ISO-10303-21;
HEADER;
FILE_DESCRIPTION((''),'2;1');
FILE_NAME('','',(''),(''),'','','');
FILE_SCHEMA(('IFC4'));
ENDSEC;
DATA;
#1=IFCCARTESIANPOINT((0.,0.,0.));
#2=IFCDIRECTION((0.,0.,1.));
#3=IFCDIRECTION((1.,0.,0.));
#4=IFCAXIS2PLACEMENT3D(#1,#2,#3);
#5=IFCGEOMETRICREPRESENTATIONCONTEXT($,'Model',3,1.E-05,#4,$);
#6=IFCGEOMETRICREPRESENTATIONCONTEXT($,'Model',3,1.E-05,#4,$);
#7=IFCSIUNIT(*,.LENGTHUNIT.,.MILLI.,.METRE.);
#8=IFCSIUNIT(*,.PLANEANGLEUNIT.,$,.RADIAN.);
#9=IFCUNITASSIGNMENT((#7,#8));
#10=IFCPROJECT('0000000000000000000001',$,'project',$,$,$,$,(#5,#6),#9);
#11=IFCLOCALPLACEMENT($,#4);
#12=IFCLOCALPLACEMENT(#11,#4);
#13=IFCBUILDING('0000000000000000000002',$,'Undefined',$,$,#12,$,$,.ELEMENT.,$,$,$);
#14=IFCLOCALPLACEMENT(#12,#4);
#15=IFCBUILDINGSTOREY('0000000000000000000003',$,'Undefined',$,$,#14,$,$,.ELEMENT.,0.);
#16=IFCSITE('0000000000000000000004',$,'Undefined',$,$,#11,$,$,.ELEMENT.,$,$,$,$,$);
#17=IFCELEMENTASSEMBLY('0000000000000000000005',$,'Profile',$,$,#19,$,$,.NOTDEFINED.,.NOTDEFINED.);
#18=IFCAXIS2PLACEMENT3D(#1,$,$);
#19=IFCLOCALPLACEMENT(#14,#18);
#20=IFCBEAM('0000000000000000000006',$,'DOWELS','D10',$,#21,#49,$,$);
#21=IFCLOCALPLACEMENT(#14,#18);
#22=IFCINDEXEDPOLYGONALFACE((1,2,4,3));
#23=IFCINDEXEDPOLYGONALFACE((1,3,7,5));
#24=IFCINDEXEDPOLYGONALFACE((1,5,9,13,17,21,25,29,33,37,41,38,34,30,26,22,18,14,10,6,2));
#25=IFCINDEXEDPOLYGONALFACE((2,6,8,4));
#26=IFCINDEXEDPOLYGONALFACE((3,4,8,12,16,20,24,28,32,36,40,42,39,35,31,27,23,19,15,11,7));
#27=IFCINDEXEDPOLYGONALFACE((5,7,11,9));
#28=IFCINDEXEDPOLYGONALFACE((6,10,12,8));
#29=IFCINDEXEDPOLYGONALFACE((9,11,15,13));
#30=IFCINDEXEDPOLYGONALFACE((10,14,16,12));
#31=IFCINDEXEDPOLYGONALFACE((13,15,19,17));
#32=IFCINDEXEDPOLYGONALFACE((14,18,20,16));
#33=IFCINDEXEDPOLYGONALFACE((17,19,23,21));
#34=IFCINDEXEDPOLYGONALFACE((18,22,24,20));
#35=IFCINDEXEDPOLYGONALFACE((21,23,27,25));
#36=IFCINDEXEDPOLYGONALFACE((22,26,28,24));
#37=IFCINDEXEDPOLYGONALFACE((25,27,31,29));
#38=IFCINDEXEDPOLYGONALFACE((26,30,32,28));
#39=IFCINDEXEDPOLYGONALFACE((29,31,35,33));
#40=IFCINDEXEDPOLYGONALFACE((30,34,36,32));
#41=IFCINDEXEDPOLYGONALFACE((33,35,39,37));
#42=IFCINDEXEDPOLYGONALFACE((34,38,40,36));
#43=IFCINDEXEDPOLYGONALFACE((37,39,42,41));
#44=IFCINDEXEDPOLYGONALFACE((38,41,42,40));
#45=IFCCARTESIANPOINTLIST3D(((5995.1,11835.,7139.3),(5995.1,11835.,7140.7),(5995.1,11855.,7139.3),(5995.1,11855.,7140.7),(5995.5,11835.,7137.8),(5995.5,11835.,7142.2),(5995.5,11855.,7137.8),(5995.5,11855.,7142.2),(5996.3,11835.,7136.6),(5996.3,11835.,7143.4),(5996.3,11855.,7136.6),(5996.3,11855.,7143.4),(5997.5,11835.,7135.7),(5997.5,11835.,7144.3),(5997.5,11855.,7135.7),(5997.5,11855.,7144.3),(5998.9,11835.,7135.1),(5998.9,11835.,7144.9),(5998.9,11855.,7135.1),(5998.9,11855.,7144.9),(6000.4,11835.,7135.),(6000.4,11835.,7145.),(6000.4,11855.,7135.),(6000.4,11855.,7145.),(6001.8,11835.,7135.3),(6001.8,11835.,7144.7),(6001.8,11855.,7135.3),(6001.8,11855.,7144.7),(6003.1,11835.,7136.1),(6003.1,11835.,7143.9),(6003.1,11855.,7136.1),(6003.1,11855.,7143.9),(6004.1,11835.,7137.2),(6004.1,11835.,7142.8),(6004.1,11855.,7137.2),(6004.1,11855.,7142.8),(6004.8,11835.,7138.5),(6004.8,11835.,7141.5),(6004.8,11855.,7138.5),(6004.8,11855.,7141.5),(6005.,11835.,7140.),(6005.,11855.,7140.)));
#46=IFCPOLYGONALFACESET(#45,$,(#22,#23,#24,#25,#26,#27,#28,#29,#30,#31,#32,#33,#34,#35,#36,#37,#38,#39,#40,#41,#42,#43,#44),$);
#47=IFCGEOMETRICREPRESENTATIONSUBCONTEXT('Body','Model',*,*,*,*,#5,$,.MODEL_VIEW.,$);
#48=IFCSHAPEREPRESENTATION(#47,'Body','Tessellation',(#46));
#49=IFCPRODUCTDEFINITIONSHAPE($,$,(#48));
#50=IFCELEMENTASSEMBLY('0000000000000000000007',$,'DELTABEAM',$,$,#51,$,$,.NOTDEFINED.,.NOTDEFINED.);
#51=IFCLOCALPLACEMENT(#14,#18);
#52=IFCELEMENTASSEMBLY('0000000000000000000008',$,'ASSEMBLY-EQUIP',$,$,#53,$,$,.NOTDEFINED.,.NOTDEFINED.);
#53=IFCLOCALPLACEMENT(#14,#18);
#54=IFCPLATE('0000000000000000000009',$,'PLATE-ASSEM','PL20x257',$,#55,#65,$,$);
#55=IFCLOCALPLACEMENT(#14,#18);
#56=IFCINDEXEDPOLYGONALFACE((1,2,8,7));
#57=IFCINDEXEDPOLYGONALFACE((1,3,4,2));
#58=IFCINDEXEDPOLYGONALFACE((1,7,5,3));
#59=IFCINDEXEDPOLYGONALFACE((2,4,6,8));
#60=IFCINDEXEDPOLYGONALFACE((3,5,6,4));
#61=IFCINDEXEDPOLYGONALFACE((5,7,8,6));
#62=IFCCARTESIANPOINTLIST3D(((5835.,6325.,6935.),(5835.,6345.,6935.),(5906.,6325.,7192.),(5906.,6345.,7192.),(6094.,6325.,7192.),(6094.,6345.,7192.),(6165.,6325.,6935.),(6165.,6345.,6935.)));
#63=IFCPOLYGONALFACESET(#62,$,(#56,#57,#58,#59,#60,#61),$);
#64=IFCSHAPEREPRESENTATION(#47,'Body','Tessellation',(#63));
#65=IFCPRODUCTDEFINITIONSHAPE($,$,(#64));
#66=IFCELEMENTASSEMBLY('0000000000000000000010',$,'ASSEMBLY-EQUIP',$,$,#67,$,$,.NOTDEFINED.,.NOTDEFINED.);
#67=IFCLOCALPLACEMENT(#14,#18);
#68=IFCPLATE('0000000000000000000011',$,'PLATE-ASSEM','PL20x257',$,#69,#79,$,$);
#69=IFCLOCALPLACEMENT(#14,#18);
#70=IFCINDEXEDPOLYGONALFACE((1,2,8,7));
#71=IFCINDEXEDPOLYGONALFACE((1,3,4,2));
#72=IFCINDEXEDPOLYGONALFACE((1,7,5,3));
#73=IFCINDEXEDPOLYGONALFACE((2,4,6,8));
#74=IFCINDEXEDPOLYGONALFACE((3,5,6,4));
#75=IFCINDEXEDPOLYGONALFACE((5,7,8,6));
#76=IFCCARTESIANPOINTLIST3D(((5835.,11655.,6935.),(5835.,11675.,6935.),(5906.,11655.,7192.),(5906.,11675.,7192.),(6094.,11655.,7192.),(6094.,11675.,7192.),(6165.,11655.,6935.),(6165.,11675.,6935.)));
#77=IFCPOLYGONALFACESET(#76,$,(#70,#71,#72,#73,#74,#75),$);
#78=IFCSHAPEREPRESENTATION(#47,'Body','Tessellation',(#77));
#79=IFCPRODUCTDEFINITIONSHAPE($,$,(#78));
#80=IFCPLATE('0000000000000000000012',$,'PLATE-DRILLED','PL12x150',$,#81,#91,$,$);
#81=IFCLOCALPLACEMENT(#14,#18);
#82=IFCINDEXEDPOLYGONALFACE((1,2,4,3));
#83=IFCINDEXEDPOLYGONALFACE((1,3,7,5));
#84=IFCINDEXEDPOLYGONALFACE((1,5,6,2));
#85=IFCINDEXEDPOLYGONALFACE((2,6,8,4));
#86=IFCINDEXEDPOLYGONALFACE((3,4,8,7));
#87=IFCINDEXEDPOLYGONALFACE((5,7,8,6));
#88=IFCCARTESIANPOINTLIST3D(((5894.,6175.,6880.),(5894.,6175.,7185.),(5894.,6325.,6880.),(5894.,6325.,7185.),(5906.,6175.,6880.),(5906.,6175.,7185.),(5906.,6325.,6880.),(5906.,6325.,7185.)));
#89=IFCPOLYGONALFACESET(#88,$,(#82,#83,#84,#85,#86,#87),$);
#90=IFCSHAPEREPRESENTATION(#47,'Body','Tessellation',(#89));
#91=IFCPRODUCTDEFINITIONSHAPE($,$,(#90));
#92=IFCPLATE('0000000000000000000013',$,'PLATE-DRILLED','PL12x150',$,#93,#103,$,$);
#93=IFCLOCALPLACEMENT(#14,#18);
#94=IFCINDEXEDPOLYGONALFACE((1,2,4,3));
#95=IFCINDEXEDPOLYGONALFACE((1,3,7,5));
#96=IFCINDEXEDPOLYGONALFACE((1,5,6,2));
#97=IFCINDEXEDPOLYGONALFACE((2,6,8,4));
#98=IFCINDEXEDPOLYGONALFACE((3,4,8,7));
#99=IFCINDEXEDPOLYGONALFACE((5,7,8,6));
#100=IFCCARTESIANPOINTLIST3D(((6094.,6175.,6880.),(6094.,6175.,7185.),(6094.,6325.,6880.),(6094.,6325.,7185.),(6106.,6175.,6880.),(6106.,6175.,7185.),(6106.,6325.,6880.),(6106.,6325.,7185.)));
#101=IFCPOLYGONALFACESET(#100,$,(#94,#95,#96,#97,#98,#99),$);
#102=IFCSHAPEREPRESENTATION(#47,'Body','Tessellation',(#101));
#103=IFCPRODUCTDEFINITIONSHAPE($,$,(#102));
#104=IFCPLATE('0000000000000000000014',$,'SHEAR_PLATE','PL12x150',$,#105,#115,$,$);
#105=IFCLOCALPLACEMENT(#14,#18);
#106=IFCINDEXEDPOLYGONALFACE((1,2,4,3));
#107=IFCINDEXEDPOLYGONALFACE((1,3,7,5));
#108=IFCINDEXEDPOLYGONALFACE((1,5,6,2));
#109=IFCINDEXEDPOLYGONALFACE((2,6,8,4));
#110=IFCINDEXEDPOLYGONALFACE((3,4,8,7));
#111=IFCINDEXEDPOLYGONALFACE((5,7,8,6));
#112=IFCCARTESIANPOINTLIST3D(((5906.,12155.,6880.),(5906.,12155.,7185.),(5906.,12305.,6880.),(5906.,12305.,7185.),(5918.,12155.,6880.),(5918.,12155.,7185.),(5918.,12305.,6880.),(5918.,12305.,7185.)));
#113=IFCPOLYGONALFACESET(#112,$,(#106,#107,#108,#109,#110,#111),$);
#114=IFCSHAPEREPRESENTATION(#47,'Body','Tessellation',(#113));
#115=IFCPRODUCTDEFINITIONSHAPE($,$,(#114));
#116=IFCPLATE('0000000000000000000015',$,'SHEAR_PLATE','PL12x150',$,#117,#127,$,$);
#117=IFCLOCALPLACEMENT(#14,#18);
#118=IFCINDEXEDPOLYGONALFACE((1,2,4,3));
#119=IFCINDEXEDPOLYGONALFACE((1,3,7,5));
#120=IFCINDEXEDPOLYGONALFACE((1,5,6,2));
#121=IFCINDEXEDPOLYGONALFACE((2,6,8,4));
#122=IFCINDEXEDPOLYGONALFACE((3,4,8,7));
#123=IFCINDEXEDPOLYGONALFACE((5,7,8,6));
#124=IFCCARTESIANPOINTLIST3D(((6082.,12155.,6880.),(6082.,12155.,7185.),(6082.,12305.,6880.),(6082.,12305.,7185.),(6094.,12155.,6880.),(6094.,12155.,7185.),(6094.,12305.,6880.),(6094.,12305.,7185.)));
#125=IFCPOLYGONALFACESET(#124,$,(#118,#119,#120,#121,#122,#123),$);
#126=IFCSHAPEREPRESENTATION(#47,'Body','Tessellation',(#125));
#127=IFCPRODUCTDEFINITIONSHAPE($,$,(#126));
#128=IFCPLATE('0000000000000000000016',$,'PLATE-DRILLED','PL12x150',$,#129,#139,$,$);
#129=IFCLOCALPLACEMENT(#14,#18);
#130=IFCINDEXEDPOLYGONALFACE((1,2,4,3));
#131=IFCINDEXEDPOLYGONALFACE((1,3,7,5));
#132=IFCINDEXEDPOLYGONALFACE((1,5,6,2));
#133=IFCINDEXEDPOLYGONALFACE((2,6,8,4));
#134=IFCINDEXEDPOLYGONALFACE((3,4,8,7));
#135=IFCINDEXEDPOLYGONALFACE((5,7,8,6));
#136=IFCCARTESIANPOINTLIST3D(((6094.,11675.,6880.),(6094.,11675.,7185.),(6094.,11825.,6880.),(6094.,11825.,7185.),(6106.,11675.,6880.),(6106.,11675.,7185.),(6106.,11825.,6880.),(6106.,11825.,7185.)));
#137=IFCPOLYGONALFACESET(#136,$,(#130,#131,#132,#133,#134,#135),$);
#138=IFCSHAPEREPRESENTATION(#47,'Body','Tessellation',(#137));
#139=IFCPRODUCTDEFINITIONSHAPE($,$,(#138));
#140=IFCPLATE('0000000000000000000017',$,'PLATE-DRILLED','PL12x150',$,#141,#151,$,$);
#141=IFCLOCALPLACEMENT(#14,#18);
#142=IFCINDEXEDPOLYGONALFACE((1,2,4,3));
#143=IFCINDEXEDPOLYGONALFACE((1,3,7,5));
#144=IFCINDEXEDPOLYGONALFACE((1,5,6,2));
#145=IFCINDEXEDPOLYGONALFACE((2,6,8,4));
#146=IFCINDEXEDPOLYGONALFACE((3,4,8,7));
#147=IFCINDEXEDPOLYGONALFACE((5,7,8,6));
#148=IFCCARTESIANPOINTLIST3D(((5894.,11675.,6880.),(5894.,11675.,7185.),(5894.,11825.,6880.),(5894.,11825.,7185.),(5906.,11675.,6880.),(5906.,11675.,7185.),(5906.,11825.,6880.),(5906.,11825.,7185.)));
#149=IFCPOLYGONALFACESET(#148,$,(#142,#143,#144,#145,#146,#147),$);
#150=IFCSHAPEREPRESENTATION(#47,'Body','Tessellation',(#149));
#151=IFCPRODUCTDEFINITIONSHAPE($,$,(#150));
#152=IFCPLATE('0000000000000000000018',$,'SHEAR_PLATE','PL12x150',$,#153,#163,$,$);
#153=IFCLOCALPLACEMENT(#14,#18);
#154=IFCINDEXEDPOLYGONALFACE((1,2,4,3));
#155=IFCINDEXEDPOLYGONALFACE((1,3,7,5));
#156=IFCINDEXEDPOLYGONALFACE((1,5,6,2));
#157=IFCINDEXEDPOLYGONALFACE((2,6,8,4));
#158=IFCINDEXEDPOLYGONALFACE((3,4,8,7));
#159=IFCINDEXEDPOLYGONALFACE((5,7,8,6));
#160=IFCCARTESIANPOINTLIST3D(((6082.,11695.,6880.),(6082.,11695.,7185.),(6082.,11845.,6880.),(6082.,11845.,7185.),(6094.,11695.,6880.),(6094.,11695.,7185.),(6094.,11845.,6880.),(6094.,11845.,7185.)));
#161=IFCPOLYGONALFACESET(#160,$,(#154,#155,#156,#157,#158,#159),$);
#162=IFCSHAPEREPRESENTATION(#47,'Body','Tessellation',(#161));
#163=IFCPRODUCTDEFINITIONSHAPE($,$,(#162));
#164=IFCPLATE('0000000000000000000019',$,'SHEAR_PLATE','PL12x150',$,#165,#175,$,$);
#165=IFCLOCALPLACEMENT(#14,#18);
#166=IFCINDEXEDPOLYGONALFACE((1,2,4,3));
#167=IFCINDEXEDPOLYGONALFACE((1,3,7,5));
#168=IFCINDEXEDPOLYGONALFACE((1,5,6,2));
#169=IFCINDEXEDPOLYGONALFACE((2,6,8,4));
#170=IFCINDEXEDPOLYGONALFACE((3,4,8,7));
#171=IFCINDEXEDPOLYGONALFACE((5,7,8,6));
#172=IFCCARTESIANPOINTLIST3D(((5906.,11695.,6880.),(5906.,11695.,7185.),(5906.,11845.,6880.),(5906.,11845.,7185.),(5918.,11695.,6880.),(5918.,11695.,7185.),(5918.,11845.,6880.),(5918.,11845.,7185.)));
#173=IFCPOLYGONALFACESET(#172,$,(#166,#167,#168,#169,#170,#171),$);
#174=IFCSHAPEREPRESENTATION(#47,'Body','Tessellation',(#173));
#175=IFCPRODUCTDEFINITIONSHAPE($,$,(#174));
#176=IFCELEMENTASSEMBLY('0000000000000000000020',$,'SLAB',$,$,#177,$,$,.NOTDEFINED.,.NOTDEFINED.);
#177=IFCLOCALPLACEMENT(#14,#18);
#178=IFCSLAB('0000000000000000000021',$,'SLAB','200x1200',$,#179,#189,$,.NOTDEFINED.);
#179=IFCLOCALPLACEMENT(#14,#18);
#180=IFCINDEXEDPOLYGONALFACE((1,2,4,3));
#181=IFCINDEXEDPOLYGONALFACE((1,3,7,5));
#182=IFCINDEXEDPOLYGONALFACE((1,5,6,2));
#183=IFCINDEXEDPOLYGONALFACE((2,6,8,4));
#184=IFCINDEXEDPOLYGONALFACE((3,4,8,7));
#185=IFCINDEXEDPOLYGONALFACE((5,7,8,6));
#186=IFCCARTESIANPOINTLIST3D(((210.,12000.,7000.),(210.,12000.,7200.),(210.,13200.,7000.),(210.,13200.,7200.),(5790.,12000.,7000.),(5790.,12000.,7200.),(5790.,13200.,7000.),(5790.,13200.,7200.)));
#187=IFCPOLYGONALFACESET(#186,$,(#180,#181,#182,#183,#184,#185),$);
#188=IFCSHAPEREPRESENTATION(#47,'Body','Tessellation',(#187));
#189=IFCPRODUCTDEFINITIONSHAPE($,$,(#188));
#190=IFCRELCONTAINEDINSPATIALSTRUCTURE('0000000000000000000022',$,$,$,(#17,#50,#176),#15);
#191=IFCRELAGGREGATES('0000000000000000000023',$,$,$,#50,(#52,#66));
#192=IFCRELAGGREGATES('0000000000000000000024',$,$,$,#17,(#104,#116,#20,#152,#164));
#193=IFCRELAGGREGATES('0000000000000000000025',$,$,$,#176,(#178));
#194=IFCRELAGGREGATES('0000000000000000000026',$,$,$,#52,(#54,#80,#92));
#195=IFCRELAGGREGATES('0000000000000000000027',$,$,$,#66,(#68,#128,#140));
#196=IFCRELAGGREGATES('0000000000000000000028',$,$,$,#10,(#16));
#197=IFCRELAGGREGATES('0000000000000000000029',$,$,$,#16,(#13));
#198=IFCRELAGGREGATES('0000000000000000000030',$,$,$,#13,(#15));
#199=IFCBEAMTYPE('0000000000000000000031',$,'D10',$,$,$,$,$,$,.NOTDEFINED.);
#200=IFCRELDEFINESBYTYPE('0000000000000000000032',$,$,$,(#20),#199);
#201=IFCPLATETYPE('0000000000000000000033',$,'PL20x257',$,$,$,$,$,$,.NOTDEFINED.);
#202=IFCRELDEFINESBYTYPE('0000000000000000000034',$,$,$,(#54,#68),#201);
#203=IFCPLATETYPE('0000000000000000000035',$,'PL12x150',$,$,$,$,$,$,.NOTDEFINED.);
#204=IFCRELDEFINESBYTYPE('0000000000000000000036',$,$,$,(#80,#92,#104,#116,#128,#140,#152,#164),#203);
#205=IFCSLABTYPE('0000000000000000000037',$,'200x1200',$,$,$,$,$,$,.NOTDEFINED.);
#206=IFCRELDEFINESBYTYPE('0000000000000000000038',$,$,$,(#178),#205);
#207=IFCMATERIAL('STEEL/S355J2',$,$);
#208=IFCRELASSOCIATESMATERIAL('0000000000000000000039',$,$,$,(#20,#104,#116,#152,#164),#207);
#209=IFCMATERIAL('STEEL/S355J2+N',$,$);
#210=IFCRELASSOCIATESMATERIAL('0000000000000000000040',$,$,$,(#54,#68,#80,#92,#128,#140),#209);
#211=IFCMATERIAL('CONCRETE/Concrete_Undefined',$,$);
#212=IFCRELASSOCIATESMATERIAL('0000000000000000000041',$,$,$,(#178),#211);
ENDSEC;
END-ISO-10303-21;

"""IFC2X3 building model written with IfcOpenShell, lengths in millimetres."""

from ifc_helpers import new_model, si_unit, frame, origin_with_axes, origin_2d_with_axis, place, context, subcontext, project, spatial, polyline, circle, outline, extrude, material, type_object, element, aggregate, save


model = new_model("IFC2X3")

# Units and contexts
model_context_1 = context("Model", 3, precision=1e-05, world=origin_with_axes())
model_context_2 = context("Model", 3, precision=1e-05, world=origin_with_axes())
body_context = subcontext(model_context_1, "Body", "Model", "MODEL_VIEW")
ifc_project = project(units=[si_unit("LENGTHUNIT", "METRE", prefix="MILLI"), si_unit("PLANEANGLEUNIT", "RADIAN")], contexts=[model_context_1, model_context_2])

# Site, building, storey
site_placement = place(None, origin_with_axes())
site = spatial("IfcSite", under=ifc_project, at=site_placement, Name="Undefined", CompositionType="ELEMENT")
building_placement = place(site_placement, origin_with_axes())
building = spatial("IfcBuilding", under=site, at=building_placement, Name="Undefined", CompositionType="ELEMENT")
storey_placement = place(building_placement, origin_with_axes())
storey = spatial("IfcBuildingStorey", under=building, at=storey_placement, Name="Undefined", CompositionType="ELEMENT", Elevation=0.0)

# Element assembly, beam
assembly_1_placement = place(storey_placement, origin_with_axes())
assembly_1 = element("IfcElementAssembly", 1, at=assembly_1_placement, inside=storey, Name="Profile", AssemblyPlace="NOTDEFINED", PredefinedType="NOTDEFINED")
ifc_material_1 = material(Name="STEEL/S355J2")
beam_type_1 = type_object("IfcBeamType", Name="D10", PredefinedType="NOTDEFINED")
beam_1_placement = place(assembly_1_placement, frame((6000.0, 11835.0, 7140.0), z_axis=(0.0, 0.0, 1.0), x_axis=(0.0, 1.0, 0.0)))
beam_1 = element("IfcBeam", 2, at=beam_1_placement, type_object=beam_type_1, material=ifc_material_1, Name="DOWELS", Description="D10", context=body_context, shape_type="SweptSolid", body=[
    extrude(circle(Radius=5.0, at=origin_2d_with_axis()), frame((20.0, 0.0, 0.0), z_axis=(-1.0, 0.0, 0.0), x_axis=(0.0, -1.0, 0.0)), (0.0, 0.0, 1.0), 20.0),
])

# Element assemblies, plates
assembly_2_placement = place(storey_placement, origin_with_axes())
assembly_2 = element("IfcElementAssembly", 3, at=assembly_2_placement, inside=storey, Name="DELTABEAM", AssemblyPlace="NOTDEFINED", PredefinedType="NOTDEFINED")
assembly_3_placement = place(assembly_2_placement, origin_with_axes())
assembly_3 = element("IfcElementAssembly", 4, at=assembly_3_placement, Name="ASSEMBLY-EQUIP", AssemblyPlace="NOTDEFINED", PredefinedType="NOTDEFINED")
ifc_material_2 = material(Name="STEEL/S355J2+N")
plate_type_1 = type_object("IfcPlateType", Name="PL20x257", PredefinedType="NOTDEFINED")
plate_1_placement = place(assembly_3_placement, frame((6165.0, 6335.0, 6935.0), z_axis=(0.0, 1.0, 0.0), x_axis=(-1.0, 0.0, 0.0)))
plate_1 = element("IfcPlate", 5, at=plate_1_placement, type_object=plate_type_1, material=ifc_material_2, Name="PLATE-ASSEM", Description="PL20x257", context=body_context, shape_type="SweptSolid", body=[
    extrude(outline(polyline([(0.0, 0.0), (330.0, 0.0), (259.0, 257.0), (71.0, 257.0), (0.0, 0.0)])), frame((0.0, 0.0, -10.0), z_axis=(0.0, 0.0, 1.0), x_axis=(1.0, 0.0, 0.0)), (0.0, 0.0, 1.0), 20.0),
])
assembly_4_placement = place(assembly_2_placement, origin_with_axes())
assembly_4 = element("IfcElementAssembly", 6, at=assembly_4_placement, Name="ASSEMBLY-EQUIP", AssemblyPlace="NOTDEFINED", PredefinedType="NOTDEFINED")
aggregate(assembly_2, [assembly_3, assembly_4])
plate_2_placement = place(assembly_4_placement, frame((5835.0, 11665.0, 6935.0), z_axis=(0.0, -1.0, 0.0), x_axis=(1.0, 0.0, 0.0)))
plate_2 = element("IfcPlate", 7, at=plate_2_placement, type_object=plate_type_1, material=ifc_material_2, Name="PLATE-ASSEM", Description="PL20x257", context=body_context, shape_type="SweptSolid", body=[
    extrude(outline(polyline([(0.0, 0.0), (330.0, 0.0), (259.0, 257.0), (71.0, 257.0), (0.0, 0.0)])), frame((0.0, 0.0, -10.0), z_axis=(0.0, 0.0, 1.0), x_axis=(1.0, 0.0, 0.0)), (0.0, 0.0, 1.0), 20.0),
])
plate_type_2 = type_object("IfcPlateType", Name="PL12x150", PredefinedType="NOTDEFINED")
plate_3_placement = place(assembly_3_placement, frame((5900.0, 6325.0, 7185.0), z_axis=(1.0, 0.0, 0.0), x_axis=(0.0, -1.0, 0.0)))
plate_3 = element("IfcPlate", 8, at=plate_3_placement, type_object=plate_type_2, material=ifc_material_2, Name="PLATE-DRILLED", Description="PL12x150", context=body_context, shape_type="SweptSolid", body=[
    extrude(outline(polyline([(0.0, 0.0), (150.0, 0.0), (150.0, 0.0), (150.0, 305.0), (150.0, 305.0), (0.0, 305.0), (0.0, 305.0), (0.0, 0.0)])), frame((0.0, 0.0, -6.0), z_axis=(0.0, 0.0, 1.0), x_axis=(1.0, 0.0, 0.0)), (0.0, 0.0, 1.0), 12.0),
])
plate_4_placement = place(assembly_3_placement, frame((6100.0, 6325.0, 7185.0), z_axis=(1.0, 0.0, 0.0), x_axis=(0.0, -1.0, 0.0)))
plate_4 = element("IfcPlate", 9, at=plate_4_placement, type_object=plate_type_2, material=ifc_material_2, Name="PLATE-DRILLED", Description="PL12x150", context=body_context, shape_type="SweptSolid", body=[
    extrude(outline(polyline([(0.0, 0.0), (150.0, 0.0), (150.0, 0.0), (150.0, 305.0), (150.0, 305.0), (0.0, 305.0), (0.0, 305.0), (0.0, 0.0)])), frame((0.0, 0.0, -6.0), z_axis=(0.0, 0.0, 1.0), x_axis=(1.0, 0.0, 0.0)), (0.0, 0.0, 1.0), 12.0),
])

# Plates
plate_5_placement = place(assembly_1_placement, frame((5912.0, 12155.0, 7185.0), z_axis=(-1.0, 0.0, 0.0), x_axis=(0.0, 1.0, 0.0)))
plate_5 = element("IfcPlate", 10, at=plate_5_placement, type_object=plate_type_2, material=ifc_material_1, Name="SHEAR_PLATE", Description="PL12x150", context=body_context, shape_type="SweptSolid", body=[
    extrude(outline(polyline([(0.0, 0.0), (150.0, 0.0), (150.0, 0.0), (150.0, 305.0), (150.0, 305.0), (0.0, 305.0), (0.0, 305.0), (0.0, 0.0)])), frame((0.0, 0.0, -6.0), z_axis=(0.0, 0.0, 1.0), x_axis=(1.0, 0.0, 0.0)), (0.0, 0.0, 1.0), 12.0),
])
plate_6_placement = place(assembly_1_placement, frame((6088.0, 12155.0, 7185.0), z_axis=(-1.0, 0.0, 0.0), x_axis=(0.0, 1.0, 0.0)))
plate_6 = element("IfcPlate", 11, at=plate_6_placement, type_object=plate_type_2, material=ifc_material_1, Name="SHEAR_PLATE", Description="PL12x150", context=body_context, shape_type="SweptSolid", body=[
    extrude(outline(polyline([(0.0, 0.0), (150.0, 0.0), (150.0, 0.0), (150.0, 305.0), (150.0, 305.0), (0.0, 305.0), (0.0, 305.0), (0.0, 0.0)])), frame((0.0, 0.0, -6.0), z_axis=(0.0, 0.0, 1.0), x_axis=(1.0, 0.0, 0.0)), (0.0, 0.0, 1.0), 12.0),
])
plate_7_placement = place(assembly_4_placement, frame((6100.0, 11675.0, 7185.0), z_axis=(-1.0, 0.0, 0.0), x_axis=(0.0, 1.0, 0.0)))
plate_7 = element("IfcPlate", 12, at=plate_7_placement, type_object=plate_type_2, material=ifc_material_2, Name="PLATE-DRILLED", Description="PL12x150", context=body_context, shape_type="SweptSolid", body=[
    extrude(outline(polyline([(0.0, 0.0), (150.0, 0.0), (150.0, 0.0), (150.0, 305.0), (150.0, 305.0), (0.0, 305.0), (0.0, 305.0), (0.0, 0.0)])), frame((0.0, 0.0, -6.0), z_axis=(0.0, 0.0, 1.0), x_axis=(1.0, 0.0, 0.0)), (0.0, 0.0, 1.0), 12.0),
])
plate_8_placement = place(assembly_4_placement, frame((5900.0, 11675.0, 7185.0), z_axis=(-1.0, 0.0, 0.0), x_axis=(0.0, 1.0, 0.0)))
plate_8 = element("IfcPlate", 13, at=plate_8_placement, type_object=plate_type_2, material=ifc_material_2, Name="PLATE-DRILLED", Description="PL12x150", context=body_context, shape_type="SweptSolid", body=[
    extrude(outline(polyline([(0.0, 0.0), (150.0, 0.0), (150.0, 0.0), (150.0, 305.0), (150.0, 305.0), (0.0, 305.0), (0.0, 305.0), (0.0, 0.0)])), frame((0.0, 0.0, -6.0), z_axis=(0.0, 0.0, 1.0), x_axis=(1.0, 0.0, 0.0)), (0.0, 0.0, 1.0), 12.0),
])
plate_9_placement = place(assembly_1_placement, frame((6088.0, 11845.0, 7185.0), z_axis=(1.0, 0.0, 0.0), x_axis=(0.0, -1.0, 0.0)))
plate_9 = element("IfcPlate", 14, at=plate_9_placement, type_object=plate_type_2, material=ifc_material_1, Name="SHEAR_PLATE", Description="PL12x150", context=body_context, shape_type="SweptSolid", body=[
    extrude(outline(polyline([(0.0, 0.0), (150.0, 0.0), (150.0, 0.0), (150.0, 305.0), (150.0, 305.0), (0.0, 305.0), (0.0, 305.0), (0.0, 0.0)])), frame((0.0, 0.0, -6.0), z_axis=(0.0, 0.0, 1.0), x_axis=(1.0, 0.0, 0.0)), (0.0, 0.0, 1.0), 12.0),
])
plate_10_placement = place(assembly_1_placement, frame((5912.0, 11845.0, 7185.0), z_axis=(1.0, 0.0, 0.0), x_axis=(0.0, -1.0, 0.0)))
plate_10 = element("IfcPlate", 15, at=plate_10_placement, type_object=plate_type_2, material=ifc_material_1, Name="SHEAR_PLATE", Description="PL12x150", context=body_context, shape_type="SweptSolid", body=[
    extrude(outline(polyline([(0.0, 0.0), (150.0, 0.0), (150.0, 0.0), (150.0, 305.0), (150.0, 305.0), (0.0, 305.0), (0.0, 305.0), (0.0, 0.0)])), frame((0.0, 0.0, -6.0), z_axis=(0.0, 0.0, 1.0), x_axis=(1.0, 0.0, 0.0)), (0.0, 0.0, 1.0), 12.0),
])
aggregate(assembly_1, [plate_5, plate_6, beam_1, plate_9, plate_10])

# Element assembly, slab
assembly_5_placement = place(storey_placement, origin_with_axes())
assembly_5 = element("IfcElementAssembly", 16, at=assembly_5_placement, inside=storey, Name="SLAB", AssemblyPlace="NOTDEFINED", PredefinedType="NOTDEFINED")
ifc_material_3 = material(Name="CONCRETE/Concrete_Undefined")
slab_type = type_object("IfcSlabType", Name="200x1200", PredefinedType="NOTDEFINED")
slab_placement = place(assembly_5_placement, frame((5790.0, 12000.0, 7100.0), z_axis=(0.0, 0.0, 1.0), x_axis=(0.0, 1.0, 0.0)))
slab = element("IfcSlab", 17, at=slab_placement, type_object=slab_type, material=ifc_material_3, Name="SLAB", Description="200x1200", PredefinedType="NOTDEFINED", context=body_context, shape_type="SweptSolid", body=[
    extrude(outline(polyline([(0.0, 0.0), (1200.0, 0.0), (1200.0, 5580.0), (0.0, 5580.0), (0.0, 0.0)])), frame((0.0, 0.0, -100.0), z_axis=(0.0, 0.0, 1.0), x_axis=(1.0, 0.0, 0.0)), (0.0, 0.0, 1.0), 200.0),
])
aggregate(assembly_5, [slab])

aggregate(assembly_3, [plate_1, plate_3, plate_4])
aggregate(assembly_4, [plate_2, plate_7, plate_8])

save(model, "model.ifc")
